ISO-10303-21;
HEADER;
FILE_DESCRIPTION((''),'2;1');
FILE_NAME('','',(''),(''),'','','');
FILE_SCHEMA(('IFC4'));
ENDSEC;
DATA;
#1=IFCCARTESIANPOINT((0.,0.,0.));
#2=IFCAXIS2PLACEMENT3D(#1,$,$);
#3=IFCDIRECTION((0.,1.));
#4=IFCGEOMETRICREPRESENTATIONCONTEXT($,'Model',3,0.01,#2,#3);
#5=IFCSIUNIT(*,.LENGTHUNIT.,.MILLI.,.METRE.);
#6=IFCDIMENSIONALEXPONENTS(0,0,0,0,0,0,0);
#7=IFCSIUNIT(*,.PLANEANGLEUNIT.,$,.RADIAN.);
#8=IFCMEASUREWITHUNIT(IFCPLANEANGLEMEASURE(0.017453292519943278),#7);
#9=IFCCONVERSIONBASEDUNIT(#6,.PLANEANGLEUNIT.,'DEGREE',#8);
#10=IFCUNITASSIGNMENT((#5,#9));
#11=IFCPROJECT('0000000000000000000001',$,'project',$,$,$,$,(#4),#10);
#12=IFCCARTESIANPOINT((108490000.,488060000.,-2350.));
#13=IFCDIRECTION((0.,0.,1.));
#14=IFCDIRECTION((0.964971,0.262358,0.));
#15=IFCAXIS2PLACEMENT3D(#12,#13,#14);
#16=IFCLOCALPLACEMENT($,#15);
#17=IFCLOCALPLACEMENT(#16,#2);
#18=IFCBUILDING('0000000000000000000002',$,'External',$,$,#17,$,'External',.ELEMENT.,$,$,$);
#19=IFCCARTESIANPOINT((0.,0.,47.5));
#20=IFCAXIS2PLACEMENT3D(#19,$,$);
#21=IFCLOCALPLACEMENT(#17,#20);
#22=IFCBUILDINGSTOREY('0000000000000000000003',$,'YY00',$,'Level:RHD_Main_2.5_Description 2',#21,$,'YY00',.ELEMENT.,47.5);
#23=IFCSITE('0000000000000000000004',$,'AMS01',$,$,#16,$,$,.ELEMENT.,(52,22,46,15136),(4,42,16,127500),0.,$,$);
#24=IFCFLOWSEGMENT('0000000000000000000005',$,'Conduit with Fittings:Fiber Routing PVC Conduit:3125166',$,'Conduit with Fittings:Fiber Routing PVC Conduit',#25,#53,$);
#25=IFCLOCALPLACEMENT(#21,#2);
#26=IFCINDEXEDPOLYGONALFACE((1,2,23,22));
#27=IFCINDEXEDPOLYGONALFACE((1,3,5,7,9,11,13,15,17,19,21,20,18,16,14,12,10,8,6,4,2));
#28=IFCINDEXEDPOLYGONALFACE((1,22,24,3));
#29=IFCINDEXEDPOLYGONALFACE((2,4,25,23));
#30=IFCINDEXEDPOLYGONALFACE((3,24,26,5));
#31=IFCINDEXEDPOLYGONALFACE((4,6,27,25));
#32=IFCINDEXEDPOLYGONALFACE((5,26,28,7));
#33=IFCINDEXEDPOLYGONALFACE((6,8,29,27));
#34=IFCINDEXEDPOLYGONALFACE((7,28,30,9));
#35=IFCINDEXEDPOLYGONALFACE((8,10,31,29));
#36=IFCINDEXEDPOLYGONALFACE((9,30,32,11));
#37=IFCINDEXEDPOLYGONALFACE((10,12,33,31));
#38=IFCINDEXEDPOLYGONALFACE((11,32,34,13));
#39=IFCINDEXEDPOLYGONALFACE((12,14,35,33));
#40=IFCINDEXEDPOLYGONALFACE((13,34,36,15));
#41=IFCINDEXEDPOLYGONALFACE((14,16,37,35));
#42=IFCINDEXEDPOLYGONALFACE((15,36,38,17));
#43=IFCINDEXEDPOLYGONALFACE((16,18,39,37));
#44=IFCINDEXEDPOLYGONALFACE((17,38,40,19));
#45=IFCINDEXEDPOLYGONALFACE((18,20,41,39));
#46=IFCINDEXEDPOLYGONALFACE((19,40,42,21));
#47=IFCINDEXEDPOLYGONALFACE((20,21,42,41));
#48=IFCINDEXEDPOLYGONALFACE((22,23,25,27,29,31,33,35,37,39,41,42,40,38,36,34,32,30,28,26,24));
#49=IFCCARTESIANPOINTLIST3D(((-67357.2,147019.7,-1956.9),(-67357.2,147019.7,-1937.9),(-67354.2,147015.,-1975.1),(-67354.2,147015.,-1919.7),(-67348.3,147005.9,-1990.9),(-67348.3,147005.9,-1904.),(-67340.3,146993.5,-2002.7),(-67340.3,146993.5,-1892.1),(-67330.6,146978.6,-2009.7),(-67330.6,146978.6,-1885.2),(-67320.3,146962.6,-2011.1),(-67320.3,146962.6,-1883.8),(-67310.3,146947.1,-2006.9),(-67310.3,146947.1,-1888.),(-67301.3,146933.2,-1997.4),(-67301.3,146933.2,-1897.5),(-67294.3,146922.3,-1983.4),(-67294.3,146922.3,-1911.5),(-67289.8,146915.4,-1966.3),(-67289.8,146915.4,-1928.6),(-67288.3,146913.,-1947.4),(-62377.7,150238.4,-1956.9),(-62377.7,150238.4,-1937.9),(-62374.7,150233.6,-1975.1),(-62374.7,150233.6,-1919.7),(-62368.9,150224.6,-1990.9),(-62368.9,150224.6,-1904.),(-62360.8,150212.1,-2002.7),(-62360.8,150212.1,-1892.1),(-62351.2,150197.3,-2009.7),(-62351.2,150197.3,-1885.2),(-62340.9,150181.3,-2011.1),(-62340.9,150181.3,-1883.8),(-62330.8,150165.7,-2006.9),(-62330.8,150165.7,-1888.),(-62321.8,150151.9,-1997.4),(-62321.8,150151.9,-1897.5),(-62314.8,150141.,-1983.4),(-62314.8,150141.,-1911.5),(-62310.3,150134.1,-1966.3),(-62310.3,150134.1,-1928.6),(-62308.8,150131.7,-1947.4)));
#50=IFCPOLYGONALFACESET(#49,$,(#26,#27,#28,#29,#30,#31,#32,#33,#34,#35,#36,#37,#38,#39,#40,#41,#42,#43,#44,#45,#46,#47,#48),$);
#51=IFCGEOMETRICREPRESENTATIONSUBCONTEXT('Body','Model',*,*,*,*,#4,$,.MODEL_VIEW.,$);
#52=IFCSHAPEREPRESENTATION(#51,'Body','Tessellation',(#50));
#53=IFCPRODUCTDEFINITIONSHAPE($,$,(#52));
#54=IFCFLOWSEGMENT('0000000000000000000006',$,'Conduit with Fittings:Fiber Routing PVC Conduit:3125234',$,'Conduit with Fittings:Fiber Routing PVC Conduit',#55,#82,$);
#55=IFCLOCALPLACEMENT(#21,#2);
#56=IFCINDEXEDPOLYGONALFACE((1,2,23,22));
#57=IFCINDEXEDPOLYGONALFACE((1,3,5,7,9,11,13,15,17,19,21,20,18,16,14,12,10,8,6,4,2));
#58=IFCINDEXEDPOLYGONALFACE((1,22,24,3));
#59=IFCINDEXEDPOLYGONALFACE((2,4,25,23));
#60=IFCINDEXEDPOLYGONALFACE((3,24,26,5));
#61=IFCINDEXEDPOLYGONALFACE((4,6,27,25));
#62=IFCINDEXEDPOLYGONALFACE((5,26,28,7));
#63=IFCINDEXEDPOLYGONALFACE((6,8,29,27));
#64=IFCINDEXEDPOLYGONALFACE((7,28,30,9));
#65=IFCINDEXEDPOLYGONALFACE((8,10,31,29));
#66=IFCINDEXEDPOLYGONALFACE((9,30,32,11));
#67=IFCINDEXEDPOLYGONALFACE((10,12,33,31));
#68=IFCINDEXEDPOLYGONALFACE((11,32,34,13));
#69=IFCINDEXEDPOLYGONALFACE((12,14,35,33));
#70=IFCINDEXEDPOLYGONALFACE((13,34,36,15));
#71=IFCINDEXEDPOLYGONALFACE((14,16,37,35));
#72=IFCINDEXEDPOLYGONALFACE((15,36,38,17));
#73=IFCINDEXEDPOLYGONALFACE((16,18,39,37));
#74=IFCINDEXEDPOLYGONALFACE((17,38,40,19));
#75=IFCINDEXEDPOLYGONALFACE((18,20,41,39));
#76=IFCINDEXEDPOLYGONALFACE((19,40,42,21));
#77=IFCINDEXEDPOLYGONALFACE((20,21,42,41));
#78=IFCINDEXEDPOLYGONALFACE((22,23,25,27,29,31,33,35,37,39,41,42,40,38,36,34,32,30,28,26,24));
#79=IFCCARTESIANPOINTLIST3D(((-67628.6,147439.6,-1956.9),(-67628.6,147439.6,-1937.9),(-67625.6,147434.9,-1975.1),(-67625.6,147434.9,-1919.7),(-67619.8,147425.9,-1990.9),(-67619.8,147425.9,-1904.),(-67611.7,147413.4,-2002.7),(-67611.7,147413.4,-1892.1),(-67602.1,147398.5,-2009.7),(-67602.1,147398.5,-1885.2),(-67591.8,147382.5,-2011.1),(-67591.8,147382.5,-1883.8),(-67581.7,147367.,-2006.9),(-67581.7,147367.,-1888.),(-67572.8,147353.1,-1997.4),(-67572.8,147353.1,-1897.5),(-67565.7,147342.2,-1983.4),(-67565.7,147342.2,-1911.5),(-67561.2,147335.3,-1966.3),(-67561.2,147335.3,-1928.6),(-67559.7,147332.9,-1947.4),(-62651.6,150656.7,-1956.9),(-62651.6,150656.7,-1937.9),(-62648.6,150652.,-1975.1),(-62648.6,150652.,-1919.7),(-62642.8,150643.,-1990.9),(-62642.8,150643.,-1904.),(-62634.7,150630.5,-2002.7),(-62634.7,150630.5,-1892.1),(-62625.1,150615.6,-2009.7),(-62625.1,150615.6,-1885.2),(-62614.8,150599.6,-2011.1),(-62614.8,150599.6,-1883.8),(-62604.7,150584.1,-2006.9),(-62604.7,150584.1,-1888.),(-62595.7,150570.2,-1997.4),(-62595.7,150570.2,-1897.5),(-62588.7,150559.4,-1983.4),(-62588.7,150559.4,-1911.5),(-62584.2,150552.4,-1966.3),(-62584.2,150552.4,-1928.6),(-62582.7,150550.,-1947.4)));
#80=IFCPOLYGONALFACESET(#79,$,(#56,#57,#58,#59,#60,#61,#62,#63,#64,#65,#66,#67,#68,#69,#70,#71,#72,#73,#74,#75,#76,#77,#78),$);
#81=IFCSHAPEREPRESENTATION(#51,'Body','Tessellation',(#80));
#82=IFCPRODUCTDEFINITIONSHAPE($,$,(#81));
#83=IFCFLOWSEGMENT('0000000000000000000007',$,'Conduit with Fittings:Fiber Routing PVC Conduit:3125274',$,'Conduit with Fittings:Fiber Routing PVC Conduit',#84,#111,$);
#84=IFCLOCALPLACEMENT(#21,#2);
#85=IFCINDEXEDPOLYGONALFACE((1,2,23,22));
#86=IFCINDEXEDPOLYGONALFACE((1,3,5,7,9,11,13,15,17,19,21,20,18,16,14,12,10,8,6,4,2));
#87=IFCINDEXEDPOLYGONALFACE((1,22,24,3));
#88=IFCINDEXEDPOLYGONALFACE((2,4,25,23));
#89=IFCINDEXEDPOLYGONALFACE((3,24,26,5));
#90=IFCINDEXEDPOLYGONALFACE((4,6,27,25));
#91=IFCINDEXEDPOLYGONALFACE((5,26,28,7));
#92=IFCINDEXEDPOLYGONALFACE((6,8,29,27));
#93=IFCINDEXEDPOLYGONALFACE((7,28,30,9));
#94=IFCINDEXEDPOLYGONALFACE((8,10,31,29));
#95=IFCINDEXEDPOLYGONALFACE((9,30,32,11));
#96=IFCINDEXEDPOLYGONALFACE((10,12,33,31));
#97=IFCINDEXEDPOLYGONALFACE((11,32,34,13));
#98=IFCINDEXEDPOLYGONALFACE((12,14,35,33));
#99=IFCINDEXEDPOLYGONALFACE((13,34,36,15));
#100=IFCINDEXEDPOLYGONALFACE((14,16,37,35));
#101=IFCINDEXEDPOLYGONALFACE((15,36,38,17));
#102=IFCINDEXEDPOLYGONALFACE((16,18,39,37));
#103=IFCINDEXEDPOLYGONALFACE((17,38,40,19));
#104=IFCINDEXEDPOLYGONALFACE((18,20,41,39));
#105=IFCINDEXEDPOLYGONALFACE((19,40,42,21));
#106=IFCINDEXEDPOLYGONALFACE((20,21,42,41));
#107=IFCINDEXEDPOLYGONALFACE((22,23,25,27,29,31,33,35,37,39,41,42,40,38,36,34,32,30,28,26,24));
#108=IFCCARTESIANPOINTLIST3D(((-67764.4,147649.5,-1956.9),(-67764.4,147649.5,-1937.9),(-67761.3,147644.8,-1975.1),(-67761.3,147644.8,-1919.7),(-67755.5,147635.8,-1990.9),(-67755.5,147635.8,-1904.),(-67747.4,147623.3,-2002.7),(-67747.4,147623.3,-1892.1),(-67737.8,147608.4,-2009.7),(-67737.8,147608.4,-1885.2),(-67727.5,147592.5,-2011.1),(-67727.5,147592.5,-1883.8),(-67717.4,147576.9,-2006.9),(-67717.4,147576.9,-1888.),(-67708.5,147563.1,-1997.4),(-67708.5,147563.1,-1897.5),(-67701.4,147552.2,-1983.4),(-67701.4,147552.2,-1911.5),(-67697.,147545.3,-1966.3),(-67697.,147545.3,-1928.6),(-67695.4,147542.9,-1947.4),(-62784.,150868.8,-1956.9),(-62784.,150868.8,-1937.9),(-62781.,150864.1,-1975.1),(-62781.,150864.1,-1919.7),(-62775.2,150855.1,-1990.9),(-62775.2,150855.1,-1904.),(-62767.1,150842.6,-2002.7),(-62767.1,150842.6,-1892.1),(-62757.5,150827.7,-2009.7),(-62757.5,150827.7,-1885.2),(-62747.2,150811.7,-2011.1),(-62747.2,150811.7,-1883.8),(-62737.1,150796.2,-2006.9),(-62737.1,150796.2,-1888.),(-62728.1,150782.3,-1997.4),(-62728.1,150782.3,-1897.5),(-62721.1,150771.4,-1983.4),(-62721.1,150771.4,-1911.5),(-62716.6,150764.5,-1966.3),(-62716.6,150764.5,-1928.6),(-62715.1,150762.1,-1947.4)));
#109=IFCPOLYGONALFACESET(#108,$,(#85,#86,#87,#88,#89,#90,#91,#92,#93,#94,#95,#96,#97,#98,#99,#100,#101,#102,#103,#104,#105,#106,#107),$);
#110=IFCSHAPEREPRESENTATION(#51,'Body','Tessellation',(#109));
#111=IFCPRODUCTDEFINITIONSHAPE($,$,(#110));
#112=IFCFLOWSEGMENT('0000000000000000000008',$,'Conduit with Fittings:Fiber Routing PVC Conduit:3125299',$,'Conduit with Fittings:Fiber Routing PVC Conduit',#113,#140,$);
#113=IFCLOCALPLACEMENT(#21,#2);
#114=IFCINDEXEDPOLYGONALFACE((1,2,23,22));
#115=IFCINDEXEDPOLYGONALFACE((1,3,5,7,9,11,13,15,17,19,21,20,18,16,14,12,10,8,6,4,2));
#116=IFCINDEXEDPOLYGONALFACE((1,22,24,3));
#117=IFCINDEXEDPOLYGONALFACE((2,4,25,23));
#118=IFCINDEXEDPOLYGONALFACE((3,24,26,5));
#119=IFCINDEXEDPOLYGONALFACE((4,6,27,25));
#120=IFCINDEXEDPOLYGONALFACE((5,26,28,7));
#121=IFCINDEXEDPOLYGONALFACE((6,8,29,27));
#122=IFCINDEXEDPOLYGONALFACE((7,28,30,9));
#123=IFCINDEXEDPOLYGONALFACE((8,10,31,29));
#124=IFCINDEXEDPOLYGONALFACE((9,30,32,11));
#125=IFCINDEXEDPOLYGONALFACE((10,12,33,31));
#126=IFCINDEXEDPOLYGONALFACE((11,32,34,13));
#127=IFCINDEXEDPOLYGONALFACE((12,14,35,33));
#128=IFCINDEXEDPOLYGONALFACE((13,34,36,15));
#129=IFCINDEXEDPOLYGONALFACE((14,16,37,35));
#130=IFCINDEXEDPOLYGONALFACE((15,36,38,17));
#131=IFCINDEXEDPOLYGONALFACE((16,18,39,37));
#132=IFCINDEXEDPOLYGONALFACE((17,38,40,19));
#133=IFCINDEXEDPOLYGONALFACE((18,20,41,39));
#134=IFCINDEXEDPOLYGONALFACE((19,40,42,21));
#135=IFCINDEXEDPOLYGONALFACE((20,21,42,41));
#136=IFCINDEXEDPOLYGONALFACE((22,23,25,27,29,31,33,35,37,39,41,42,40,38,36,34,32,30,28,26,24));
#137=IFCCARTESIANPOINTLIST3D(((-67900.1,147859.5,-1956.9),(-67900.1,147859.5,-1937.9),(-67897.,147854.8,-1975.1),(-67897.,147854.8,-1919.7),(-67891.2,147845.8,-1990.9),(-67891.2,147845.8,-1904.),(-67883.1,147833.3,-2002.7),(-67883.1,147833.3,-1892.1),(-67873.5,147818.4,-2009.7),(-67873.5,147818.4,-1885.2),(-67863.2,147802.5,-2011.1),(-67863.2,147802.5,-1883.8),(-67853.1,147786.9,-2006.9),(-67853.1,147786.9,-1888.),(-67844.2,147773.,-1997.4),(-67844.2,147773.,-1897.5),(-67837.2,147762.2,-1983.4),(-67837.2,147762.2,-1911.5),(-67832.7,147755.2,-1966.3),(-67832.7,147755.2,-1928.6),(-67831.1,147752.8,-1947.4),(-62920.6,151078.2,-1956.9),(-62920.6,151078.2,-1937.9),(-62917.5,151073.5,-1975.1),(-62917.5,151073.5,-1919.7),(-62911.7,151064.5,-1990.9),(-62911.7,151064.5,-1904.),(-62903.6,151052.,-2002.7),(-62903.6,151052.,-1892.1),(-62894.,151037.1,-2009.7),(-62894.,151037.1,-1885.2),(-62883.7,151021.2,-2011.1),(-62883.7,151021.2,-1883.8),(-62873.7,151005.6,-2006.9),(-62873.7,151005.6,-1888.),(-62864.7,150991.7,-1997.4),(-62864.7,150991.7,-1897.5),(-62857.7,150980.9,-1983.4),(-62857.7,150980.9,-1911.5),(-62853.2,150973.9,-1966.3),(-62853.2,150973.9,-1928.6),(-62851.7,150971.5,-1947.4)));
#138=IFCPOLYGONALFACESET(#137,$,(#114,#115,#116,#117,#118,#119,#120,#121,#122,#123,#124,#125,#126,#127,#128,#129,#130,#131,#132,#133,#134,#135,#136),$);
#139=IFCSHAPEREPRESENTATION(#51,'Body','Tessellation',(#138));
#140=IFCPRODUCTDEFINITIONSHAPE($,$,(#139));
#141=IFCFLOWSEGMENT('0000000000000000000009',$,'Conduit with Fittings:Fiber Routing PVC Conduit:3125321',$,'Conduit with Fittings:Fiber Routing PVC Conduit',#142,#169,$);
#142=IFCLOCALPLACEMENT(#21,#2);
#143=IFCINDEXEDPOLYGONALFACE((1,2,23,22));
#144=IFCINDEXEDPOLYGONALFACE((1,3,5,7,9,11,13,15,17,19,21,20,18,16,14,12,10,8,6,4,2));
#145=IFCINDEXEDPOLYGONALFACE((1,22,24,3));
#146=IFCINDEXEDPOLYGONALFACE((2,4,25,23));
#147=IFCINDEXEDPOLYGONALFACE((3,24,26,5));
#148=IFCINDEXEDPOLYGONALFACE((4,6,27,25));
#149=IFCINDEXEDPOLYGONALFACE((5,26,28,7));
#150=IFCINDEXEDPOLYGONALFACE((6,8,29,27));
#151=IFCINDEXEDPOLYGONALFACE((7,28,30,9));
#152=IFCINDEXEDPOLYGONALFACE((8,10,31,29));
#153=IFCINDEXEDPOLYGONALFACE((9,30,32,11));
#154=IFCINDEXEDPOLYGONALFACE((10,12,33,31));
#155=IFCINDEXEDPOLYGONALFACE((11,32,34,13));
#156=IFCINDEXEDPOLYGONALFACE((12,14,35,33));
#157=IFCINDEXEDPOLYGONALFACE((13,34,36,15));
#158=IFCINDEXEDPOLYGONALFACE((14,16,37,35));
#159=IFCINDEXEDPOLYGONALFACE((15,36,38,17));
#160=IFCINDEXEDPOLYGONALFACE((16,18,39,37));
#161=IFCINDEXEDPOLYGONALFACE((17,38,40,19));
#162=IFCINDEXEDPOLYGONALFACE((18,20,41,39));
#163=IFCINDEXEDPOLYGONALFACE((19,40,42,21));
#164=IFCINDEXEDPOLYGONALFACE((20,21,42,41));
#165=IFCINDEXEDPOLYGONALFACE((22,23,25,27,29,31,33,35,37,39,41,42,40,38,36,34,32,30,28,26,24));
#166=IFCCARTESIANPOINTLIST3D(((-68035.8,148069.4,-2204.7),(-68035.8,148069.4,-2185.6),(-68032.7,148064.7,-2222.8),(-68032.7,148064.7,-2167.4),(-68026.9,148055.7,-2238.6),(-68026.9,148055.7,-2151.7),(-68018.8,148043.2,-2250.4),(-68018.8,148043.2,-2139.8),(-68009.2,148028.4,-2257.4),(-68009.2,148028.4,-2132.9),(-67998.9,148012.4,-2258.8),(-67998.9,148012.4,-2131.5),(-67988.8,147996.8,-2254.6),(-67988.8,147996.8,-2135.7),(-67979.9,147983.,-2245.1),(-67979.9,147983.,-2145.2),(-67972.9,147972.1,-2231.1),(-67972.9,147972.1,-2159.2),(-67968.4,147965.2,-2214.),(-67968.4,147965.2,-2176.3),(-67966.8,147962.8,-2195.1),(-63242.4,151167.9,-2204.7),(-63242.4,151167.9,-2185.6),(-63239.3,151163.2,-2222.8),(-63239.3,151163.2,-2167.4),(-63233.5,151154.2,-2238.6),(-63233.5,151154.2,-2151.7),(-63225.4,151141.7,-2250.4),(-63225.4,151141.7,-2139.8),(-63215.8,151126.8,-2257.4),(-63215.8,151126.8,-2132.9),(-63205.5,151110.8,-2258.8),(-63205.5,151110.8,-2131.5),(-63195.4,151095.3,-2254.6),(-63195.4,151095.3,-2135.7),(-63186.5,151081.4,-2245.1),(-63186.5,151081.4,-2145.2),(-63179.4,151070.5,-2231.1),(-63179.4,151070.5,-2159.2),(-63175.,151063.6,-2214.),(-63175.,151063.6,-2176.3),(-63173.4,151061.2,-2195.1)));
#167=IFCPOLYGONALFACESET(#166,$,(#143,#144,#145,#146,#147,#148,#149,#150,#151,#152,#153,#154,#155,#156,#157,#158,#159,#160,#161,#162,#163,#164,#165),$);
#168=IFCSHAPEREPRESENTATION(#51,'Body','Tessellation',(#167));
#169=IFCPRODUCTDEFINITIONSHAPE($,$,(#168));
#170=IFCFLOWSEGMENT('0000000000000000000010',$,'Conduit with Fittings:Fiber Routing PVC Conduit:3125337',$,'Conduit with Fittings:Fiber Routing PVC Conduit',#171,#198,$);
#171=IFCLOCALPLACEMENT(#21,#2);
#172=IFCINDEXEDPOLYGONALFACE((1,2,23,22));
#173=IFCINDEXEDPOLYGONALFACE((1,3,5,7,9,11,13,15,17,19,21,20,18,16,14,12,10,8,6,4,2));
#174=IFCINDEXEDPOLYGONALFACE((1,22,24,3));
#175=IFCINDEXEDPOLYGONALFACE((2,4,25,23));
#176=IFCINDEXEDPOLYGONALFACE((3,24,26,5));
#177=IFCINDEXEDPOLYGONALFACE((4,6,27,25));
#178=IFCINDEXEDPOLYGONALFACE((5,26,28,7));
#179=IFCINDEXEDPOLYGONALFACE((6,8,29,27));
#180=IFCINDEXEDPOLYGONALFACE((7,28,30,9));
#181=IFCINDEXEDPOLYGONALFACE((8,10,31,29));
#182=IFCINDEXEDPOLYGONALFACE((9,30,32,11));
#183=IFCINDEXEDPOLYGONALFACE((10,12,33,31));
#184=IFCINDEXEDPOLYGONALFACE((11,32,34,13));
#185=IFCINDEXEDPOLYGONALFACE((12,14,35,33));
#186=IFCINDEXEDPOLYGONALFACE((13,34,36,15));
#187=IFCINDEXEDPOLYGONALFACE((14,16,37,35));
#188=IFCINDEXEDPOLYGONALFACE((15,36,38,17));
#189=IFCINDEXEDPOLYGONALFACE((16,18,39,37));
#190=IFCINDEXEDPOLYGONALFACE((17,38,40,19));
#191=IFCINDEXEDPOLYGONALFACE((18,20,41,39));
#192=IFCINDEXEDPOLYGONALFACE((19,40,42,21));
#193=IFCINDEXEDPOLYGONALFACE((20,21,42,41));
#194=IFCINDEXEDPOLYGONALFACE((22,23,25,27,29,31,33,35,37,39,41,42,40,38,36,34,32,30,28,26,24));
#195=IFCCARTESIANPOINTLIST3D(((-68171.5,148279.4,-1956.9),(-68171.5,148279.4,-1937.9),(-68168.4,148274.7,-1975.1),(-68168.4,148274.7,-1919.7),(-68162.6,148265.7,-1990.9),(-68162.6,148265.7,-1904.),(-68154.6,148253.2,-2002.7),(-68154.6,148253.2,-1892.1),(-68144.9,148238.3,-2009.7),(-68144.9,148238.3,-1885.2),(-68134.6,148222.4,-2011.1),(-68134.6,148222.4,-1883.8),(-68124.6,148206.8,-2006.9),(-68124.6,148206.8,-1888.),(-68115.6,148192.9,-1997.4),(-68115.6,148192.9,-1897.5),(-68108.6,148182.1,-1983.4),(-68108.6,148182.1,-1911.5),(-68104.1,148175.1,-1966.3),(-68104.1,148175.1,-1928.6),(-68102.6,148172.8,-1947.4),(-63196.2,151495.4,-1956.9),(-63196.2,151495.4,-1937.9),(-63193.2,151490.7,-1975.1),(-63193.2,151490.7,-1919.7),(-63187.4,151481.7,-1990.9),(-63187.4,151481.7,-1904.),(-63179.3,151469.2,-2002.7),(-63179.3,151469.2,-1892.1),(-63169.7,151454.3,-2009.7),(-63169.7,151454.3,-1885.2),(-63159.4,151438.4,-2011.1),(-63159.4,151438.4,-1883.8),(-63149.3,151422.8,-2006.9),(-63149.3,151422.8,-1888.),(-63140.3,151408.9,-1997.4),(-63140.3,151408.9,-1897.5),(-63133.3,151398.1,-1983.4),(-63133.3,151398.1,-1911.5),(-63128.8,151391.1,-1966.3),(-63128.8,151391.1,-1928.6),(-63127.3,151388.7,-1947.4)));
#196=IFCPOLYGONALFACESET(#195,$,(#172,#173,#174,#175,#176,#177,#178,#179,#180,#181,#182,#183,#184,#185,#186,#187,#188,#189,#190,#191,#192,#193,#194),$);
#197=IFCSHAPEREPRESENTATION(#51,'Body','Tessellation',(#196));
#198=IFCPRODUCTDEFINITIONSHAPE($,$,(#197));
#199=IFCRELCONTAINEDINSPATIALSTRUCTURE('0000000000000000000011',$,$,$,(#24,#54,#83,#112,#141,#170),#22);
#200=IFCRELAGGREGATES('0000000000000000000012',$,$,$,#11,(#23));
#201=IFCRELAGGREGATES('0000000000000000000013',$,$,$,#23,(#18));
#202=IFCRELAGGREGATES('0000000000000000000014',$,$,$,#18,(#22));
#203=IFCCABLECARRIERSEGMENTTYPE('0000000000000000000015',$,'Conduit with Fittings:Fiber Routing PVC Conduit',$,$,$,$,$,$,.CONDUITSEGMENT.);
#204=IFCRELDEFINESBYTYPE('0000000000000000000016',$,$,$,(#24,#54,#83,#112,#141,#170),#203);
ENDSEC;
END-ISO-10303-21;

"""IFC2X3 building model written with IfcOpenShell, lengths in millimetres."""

from ifc_helpers import new_model, entity, si_unit, converted_unit, direction, frame, frame_2d, origin, origin_2d_with_axis, place, context, subcontext, project, spatial, circle, extrude, type_object, element, save


model = new_model("IFC2X3")

# Units and contexts
model_context = context("Model", 3, precision=0.01, world=origin(), true_north=direction((0.0, 1.0)))
body_context = subcontext(model_context, "Body", "Model", "MODEL_VIEW")
ifc_project = project(units=[si_unit("LENGTHUNIT", "METRE", prefix="MILLI"), converted_unit("PLANEANGLEUNIT", "DEGREE", entity("IfcPlaneAngleMeasure", 0.017453292519943278), si_unit("PLANEANGLEUNIT", "RADIAN"), dimensions=[0, 0, 0, 0, 0, 0, 0])], contexts=[model_context])

# Site, building, storey
site_placement = place(None, frame((108490000.0, 488060000.0, -2350.0), z_axis=(0.0, 0.0, 1.0), x_axis=(0.964971, 0.262358, 0.0)))
site = spatial("IfcSite", under=ifc_project, at=site_placement, Name="AMS01", CompositionType="ELEMENT", RefLatitude=(52, 22, 46, 15136), RefLongitude=(4, 42, 16, 127500), RefElevation=0.0)
building_placement = place(site_placement, origin())
building = spatial("IfcBuilding", under=site, at=building_placement, Name="External", LongName="External", CompositionType="ELEMENT")
storey_placement = place(building_placement, frame((0.0, 0.0, 47.5)))
storey = spatial("IfcBuildingStorey", under=building, at=storey_placement, Name="YY00", ObjectType="Level:RHD_Main_2.5_Description 2", LongName="YY00", CompositionType="ELEMENT", Elevation=47.5)

# Flow segments
cable_carrier_segment_type = type_object("IfcCableCarrierSegmentType", Name="Conduit with Fittings:Fiber Routing PVC Conduit", PredefinedType="CONDUITSEGMENT")
flow_segment_1_placement = place(storey_placement, origin())
element("IfcFlowSegment", 1, at=flow_segment_1_placement, inside=storey, type_object=cable_carrier_segment_type, Name="Conduit with Fittings:Fiber Routing PVC Conduit:3125166", ObjectType="Conduit with Fittings:Fiber Routing PVC Conduit", context=body_context, shape_type="SweptSolid", body=[
    extrude(circle(Radius=63.9, at=origin_2d_with_axis()), frame((-67322.9, 146966.6, -1947.4), z_axis=(0.839826, 0.542856, 0.0), x_axis=(0.542856, -0.839826, 0.0)), (0.0, 0.0, 1.0), 5929.2),
])
flow_segment_2_placement = place(storey_placement, origin())
element("IfcFlowSegment", 2, at=flow_segment_2_placement, inside=storey, type_object=cable_carrier_segment_type, Name="Conduit with Fittings:Fiber Routing PVC Conduit:3125234", ObjectType="Conduit with Fittings:Fiber Routing PVC Conduit", context=body_context, shape_type="SweptSolid", body=[
    extrude(circle(Radius=63.9, at=origin_2d_with_axis()), frame((-67594.4, 147386.6, -1947.4), z_axis=(0.839826, 0.542856, 0.0), x_axis=(0.542856, -0.839826, 0.0)), (0.0, 0.0, 1.0), 5926.2),
])
flow_segment_3_placement = place(storey_placement, origin())
element("IfcFlowSegment", 3, at=flow_segment_3_placement, inside=storey, type_object=cable_carrier_segment_type, Name="Conduit with Fittings:Fiber Routing PVC Conduit:3125274", ObjectType="Conduit with Fittings:Fiber Routing PVC Conduit", context=body_context, shape_type="SweptSolid", body=[
    extrude(circle(Radius=63.9, at=frame_2d((0.0, 0.0), x_axis=(1.0, 0.0))), frame((-67730.1, 147596.5, -1947.4), z_axis=(0.839826, 0.542856, 0.0), x_axis=(0.542856, -0.839826, 0.0)), (0.0, 0.0, 1.0), 5930.2),
])
flow_segment_4_placement = place(storey_placement, origin())
element("IfcFlowSegment", 4, at=flow_segment_4_placement, inside=storey, type_object=cable_carrier_segment_type, Name="Conduit with Fittings:Fiber Routing PVC Conduit:3125299", ObjectType="Conduit with Fittings:Fiber Routing PVC Conduit", context=body_context, shape_type="SweptSolid", body=[
    extrude(circle(Radius=63.9, at=origin_2d_with_axis()), frame((-67865.8, 147806.5, -1947.4), z_axis=(0.839826, 0.542856, 0.0), x_axis=(0.542856, -0.839826, 0.0)), (0.0, 0.0, 1.0), 5929.2),
])
flow_segment_5_placement = place(storey_placement, origin())
element("IfcFlowSegment", 5, at=flow_segment_5_placement, inside=storey, type_object=cable_carrier_segment_type, Name="Conduit with Fittings:Fiber Routing PVC Conduit:3125321", ObjectType="Conduit with Fittings:Fiber Routing PVC Conduit", context=body_context, shape_type="SweptSolid", body=[
    extrude(circle(Radius=63.9, at=origin_2d_with_axis()), frame((-68001.5, 148016.4, -2195.1), z_axis=(0.839826, 0.542856, 0.0), x_axis=(0.542856, -0.839826, 0.0)), (0.0, 0.0, 1.0), 5707.6),
])
flow_segment_6_placement = place(storey_placement, origin())
element("IfcFlowSegment", 6, at=flow_segment_6_placement, inside=storey, type_object=cable_carrier_segment_type, Name="Conduit with Fittings:Fiber Routing PVC Conduit:3125337", ObjectType="Conduit with Fittings:Fiber Routing PVC Conduit", context=body_context, shape_type="SweptSolid", body=[
    extrude(circle(Radius=63.9, at=origin_2d_with_axis()), frame((-68137.2, 148226.4, -1947.4), z_axis=(0.839826, 0.542856, 0.0), x_axis=(0.542856, -0.839826, 0.0)), (0.0, 0.0, 1.0), 5924.2),
])

save(model, "model.ifc")
